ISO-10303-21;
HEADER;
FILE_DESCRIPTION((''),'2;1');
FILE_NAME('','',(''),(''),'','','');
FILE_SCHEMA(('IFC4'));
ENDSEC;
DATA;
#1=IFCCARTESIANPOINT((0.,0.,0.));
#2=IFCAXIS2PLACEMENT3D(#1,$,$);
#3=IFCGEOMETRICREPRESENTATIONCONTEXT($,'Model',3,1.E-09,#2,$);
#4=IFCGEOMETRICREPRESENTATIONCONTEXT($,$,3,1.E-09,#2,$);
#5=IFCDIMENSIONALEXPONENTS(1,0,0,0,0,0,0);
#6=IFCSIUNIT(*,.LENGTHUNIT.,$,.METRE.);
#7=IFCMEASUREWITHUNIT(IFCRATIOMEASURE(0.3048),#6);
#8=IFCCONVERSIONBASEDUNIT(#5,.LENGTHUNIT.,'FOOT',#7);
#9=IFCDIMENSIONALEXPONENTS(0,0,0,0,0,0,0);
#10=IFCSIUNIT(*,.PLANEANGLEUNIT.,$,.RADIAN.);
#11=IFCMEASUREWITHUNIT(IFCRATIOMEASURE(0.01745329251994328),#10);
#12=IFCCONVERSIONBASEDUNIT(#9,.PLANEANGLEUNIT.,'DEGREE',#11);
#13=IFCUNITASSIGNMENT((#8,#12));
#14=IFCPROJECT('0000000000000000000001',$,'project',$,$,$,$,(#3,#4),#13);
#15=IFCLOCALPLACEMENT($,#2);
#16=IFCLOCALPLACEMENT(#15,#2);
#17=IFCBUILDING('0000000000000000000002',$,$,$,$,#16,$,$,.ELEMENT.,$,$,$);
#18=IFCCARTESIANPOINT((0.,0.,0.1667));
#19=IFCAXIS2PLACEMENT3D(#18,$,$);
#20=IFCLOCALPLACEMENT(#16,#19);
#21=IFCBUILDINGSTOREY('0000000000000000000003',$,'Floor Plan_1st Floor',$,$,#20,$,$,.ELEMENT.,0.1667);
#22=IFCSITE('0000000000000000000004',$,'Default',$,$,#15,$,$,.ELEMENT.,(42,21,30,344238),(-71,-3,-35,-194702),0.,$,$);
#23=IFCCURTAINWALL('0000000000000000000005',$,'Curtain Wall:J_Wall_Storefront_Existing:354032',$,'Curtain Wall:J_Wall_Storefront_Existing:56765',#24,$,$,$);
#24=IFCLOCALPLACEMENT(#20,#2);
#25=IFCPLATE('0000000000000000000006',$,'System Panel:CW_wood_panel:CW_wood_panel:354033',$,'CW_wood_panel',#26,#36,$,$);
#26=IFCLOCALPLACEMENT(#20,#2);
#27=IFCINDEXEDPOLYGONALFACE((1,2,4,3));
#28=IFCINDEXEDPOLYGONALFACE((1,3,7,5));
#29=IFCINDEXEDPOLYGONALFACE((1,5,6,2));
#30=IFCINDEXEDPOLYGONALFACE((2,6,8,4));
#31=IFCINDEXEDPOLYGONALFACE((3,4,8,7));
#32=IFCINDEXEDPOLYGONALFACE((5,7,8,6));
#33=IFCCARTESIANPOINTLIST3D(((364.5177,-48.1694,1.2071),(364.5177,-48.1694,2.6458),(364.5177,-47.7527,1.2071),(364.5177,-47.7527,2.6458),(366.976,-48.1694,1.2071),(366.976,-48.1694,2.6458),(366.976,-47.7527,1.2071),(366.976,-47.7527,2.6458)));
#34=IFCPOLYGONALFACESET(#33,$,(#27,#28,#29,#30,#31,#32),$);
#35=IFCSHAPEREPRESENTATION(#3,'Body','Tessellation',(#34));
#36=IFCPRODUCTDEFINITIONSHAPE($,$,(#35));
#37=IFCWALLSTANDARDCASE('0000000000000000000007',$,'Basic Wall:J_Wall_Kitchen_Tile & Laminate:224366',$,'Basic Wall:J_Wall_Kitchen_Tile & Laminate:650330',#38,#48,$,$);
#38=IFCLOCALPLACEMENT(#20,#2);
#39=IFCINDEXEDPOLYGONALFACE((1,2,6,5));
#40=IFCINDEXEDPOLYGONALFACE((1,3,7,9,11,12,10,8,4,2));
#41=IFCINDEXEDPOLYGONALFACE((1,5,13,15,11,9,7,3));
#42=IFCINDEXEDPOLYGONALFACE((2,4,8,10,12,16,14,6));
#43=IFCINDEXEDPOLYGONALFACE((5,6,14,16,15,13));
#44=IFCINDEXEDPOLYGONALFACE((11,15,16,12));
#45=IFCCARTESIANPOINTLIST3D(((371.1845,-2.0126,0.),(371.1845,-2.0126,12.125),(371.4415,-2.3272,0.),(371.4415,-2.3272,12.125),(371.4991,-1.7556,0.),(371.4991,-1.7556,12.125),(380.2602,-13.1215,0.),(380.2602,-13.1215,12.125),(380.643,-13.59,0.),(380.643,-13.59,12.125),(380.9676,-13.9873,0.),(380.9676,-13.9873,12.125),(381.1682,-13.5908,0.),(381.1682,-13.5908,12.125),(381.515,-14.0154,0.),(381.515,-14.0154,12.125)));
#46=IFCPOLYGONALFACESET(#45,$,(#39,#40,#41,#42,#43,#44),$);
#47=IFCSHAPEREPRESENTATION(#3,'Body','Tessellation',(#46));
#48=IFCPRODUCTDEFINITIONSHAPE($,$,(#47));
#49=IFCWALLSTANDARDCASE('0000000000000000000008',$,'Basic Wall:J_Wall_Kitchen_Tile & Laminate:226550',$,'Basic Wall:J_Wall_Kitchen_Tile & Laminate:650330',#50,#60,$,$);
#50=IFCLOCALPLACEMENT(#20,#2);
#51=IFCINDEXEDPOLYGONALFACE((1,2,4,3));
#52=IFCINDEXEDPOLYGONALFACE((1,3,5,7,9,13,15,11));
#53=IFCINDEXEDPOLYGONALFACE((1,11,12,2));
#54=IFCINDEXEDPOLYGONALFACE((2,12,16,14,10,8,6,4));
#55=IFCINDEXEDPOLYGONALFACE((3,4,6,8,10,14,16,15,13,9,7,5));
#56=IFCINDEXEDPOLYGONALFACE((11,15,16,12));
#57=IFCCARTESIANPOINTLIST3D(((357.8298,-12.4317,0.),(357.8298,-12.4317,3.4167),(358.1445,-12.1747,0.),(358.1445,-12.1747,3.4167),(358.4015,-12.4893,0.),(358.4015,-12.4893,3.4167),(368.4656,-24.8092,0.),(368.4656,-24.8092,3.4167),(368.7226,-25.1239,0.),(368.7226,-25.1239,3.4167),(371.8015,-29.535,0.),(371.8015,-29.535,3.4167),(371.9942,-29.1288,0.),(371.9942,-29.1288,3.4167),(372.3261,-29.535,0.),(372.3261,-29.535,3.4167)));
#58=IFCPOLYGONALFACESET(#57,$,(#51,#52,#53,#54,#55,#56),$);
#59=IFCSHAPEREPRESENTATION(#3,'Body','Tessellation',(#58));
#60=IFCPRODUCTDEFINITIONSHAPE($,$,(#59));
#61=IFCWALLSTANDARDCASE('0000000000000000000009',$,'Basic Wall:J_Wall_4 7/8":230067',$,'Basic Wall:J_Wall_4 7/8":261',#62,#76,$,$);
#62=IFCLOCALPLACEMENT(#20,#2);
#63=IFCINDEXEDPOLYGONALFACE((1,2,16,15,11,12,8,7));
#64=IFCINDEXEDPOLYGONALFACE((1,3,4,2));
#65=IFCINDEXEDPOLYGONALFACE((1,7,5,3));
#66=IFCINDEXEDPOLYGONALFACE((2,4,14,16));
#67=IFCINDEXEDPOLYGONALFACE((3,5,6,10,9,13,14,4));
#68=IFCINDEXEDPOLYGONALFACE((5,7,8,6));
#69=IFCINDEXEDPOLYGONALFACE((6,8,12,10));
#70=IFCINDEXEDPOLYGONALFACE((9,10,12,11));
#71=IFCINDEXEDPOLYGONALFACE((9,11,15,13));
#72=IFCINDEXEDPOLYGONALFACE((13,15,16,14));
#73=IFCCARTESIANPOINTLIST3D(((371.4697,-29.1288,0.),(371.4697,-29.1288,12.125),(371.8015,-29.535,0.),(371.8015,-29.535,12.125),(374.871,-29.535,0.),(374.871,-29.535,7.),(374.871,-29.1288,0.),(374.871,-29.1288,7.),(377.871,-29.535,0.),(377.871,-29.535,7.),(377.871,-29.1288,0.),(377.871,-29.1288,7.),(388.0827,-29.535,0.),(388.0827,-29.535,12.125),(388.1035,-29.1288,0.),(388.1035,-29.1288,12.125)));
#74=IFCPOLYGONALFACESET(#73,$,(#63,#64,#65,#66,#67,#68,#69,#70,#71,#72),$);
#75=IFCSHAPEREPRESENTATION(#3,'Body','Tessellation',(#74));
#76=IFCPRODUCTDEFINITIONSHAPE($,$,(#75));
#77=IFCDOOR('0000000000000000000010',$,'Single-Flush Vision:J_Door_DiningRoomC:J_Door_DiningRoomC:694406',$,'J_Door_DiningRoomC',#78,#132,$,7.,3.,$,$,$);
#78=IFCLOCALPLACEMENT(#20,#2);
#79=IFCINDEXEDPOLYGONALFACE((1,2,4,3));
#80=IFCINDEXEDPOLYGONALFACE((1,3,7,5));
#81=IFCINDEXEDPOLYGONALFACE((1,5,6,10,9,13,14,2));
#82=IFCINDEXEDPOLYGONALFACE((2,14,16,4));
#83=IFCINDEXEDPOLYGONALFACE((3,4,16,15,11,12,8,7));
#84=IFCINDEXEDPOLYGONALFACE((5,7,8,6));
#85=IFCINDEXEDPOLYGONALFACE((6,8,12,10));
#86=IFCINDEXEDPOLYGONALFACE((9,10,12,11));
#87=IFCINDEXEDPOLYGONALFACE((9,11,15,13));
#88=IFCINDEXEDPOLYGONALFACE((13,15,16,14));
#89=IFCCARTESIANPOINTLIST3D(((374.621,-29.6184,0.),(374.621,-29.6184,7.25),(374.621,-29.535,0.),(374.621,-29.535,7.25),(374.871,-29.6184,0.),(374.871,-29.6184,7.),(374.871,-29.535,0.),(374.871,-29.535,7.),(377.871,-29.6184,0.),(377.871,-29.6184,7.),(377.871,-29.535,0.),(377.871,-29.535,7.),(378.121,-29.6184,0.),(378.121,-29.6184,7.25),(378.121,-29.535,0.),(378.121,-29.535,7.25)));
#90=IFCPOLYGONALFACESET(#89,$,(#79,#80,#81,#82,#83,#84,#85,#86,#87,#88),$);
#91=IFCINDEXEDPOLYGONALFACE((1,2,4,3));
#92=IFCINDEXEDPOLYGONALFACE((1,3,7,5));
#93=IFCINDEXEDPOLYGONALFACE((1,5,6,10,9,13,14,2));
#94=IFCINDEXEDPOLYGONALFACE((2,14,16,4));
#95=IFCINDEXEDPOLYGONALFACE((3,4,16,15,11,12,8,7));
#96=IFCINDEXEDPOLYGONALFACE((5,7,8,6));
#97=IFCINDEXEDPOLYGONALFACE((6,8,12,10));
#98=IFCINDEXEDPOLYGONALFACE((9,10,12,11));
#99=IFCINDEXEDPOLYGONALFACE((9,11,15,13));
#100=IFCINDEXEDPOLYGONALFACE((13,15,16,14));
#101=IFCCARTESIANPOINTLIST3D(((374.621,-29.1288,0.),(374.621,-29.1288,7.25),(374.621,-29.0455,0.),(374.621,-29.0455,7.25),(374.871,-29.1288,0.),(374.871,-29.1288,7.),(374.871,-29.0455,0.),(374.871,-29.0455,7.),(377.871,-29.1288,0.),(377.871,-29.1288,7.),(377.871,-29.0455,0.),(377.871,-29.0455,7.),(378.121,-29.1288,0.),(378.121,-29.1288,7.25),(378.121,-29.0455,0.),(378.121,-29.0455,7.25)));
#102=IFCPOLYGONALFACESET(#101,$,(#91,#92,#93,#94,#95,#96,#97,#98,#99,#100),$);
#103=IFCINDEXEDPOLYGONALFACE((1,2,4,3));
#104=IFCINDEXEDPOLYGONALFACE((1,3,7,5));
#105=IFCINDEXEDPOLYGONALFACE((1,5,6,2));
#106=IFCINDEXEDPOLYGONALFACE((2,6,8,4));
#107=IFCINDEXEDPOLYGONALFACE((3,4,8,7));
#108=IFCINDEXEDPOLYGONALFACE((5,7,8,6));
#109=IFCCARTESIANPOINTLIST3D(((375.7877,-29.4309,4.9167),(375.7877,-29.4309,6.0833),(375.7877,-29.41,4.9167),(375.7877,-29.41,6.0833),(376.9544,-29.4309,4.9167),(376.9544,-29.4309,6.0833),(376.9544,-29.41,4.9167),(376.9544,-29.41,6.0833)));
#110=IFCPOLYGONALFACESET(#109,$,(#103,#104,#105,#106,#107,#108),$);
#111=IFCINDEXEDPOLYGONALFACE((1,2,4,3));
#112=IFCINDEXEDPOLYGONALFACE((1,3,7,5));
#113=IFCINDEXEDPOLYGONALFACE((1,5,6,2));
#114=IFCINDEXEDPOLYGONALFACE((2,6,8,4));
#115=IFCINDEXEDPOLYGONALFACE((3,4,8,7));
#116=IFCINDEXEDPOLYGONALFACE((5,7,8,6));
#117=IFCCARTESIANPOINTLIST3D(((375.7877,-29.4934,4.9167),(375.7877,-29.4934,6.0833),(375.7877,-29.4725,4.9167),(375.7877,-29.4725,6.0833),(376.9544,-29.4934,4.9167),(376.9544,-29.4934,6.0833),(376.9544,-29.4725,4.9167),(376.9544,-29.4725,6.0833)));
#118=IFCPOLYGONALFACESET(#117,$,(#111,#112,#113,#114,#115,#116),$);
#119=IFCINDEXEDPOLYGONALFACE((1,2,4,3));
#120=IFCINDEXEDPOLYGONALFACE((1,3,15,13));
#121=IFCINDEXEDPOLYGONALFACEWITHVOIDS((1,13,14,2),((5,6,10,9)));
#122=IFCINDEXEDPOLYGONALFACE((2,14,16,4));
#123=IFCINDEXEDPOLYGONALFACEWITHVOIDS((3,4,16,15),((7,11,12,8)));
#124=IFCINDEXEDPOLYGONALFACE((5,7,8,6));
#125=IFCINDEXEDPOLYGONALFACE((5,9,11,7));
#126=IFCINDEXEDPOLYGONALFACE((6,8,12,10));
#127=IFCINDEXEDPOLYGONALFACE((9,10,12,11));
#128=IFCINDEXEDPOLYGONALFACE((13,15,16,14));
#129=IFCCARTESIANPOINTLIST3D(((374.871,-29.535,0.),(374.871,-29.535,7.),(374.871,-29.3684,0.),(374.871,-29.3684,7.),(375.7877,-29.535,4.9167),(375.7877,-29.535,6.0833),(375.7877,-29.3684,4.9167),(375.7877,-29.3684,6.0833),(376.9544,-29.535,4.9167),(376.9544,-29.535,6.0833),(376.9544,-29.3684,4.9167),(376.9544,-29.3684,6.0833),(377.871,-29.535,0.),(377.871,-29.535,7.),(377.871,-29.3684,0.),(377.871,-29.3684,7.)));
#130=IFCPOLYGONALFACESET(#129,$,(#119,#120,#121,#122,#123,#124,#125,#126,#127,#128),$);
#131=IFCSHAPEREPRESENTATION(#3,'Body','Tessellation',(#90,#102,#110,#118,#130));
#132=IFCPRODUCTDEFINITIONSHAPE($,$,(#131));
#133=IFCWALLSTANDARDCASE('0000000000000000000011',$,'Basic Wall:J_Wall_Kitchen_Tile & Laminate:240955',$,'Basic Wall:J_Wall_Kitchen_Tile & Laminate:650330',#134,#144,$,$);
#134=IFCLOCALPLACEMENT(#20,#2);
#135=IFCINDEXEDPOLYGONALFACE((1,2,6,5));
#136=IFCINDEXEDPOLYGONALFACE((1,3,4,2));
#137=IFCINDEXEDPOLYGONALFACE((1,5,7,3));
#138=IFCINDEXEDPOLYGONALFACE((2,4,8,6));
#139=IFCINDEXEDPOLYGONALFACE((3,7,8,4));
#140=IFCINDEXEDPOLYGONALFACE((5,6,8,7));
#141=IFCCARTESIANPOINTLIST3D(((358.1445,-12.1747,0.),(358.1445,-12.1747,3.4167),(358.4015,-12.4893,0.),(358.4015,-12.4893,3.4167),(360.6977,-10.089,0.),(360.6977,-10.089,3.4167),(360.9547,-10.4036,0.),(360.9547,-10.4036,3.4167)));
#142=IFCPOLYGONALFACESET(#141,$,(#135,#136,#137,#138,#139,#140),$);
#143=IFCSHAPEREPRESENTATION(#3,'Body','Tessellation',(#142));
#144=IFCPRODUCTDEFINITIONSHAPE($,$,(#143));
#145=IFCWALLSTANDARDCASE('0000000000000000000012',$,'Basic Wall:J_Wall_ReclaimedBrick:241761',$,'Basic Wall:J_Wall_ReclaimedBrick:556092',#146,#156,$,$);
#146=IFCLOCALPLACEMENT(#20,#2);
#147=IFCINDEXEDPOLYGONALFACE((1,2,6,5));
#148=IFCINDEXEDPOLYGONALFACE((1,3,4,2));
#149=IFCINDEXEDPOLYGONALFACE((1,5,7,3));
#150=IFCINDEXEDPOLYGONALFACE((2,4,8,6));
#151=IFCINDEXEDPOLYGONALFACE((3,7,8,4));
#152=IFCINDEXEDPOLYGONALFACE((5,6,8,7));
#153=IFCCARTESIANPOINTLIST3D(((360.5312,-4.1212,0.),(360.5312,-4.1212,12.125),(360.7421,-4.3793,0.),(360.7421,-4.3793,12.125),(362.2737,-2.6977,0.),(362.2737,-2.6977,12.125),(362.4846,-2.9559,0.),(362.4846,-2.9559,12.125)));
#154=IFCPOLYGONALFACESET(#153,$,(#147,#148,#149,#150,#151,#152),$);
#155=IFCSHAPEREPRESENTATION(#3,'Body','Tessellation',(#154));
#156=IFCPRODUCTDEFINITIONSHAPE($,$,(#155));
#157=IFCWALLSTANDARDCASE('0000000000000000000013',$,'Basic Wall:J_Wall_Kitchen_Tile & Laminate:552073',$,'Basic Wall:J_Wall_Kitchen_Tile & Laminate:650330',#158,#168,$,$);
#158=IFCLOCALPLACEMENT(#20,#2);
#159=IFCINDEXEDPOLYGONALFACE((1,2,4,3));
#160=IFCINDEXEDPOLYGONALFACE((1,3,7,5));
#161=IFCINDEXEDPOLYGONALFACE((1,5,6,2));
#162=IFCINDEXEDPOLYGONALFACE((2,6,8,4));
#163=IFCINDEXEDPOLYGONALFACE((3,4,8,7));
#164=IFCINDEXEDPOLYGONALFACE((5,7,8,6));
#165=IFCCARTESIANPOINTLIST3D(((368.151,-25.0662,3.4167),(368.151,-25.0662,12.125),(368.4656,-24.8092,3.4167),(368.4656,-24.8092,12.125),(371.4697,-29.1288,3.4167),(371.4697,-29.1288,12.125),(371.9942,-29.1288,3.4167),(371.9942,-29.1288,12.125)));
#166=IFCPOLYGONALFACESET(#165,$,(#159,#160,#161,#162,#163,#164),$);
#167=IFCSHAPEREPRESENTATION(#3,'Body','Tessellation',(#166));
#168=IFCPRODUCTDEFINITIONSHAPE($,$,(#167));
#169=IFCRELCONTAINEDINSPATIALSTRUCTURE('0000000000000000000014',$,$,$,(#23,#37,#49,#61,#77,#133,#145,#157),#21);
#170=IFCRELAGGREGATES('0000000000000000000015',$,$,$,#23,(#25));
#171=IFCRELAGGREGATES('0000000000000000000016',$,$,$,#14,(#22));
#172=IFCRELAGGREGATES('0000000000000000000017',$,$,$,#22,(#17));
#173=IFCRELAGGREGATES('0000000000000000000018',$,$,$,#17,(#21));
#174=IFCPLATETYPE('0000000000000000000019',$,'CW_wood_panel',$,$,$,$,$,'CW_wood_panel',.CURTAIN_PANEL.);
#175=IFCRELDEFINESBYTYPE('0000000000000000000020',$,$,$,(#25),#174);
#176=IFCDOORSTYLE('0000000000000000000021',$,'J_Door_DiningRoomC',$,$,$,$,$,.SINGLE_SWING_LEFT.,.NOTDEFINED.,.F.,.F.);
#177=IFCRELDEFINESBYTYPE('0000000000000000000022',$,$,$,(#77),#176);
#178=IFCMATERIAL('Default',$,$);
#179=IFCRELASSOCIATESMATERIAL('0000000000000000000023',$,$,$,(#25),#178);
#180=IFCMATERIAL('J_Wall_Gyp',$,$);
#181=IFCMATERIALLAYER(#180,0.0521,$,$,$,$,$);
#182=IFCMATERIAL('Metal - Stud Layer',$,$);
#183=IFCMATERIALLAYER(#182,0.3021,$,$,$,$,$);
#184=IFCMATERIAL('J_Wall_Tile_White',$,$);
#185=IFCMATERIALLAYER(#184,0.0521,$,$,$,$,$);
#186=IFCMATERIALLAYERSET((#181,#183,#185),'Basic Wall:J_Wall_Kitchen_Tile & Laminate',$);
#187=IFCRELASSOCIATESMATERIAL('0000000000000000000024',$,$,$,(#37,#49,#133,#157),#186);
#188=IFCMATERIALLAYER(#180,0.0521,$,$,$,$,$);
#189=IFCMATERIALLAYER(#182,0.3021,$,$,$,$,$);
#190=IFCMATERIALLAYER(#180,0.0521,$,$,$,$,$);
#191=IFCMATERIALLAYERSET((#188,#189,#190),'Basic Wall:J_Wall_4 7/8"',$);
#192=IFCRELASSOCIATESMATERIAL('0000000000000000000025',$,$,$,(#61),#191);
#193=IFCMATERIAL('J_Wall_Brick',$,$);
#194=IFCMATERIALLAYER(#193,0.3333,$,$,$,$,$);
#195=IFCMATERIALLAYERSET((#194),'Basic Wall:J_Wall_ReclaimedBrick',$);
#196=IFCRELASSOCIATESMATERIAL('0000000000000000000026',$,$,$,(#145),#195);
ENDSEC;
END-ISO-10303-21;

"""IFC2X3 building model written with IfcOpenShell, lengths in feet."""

from ifc_helpers import new_model, entity, si_unit, converted_unit, frame, frame_2d, origin, origin_2d_with_axis, place, context, project, spatial, polyline, rectangle, outline, extrude, source, transform, mapped, material, layer, layer_set, layer_usage, type_object, type_shapes, element, fill, aggregate, save


model = new_model("IFC2X3")

# Units and contexts
model_context = context("Model", 3, precision=1e-09, world=origin())
context_of_model = context(None, 3, precision=1e-09, world=origin())
ifc_project = project(units=[converted_unit("LENGTHUNIT", "FOOT", entity("IfcRatioMeasure", 0.3048), si_unit("LENGTHUNIT", "METRE"), dimensions=[1, 0, 0, 0, 0, 0, 0]), converted_unit("PLANEANGLEUNIT", "DEGREE", entity("IfcRatioMeasure", 0.01745329251994328), si_unit("PLANEANGLEUNIT", "RADIAN"), dimensions=[0, 0, 0, 0, 0, 0, 0])], contexts=[model_context, context_of_model])

# Site, building, storey
site_placement = place(None, origin())
site = spatial("IfcSite", under=ifc_project, at=site_placement, Name="Default", CompositionType="ELEMENT", RefLatitude=(42, 21, 30, 344238), RefLongitude=(-71, -3, -35, -194702), RefElevation=0.0)
building_placement = place(site_placement, origin())
building = spatial("IfcBuilding", under=site, at=building_placement, CompositionType="ELEMENT")
storey_placement = place(building_placement, frame((0.0, 0.0, 0.1667)))
storey = spatial("IfcBuildingStorey", under=building, at=storey_placement, Name="Floor Plan_1st Floor", CompositionType="ELEMENT", Elevation=0.1667)

# Curtain wall
curtain_wall_1_placement = place(storey_placement, origin())
curtain_wall_1 = element("IfcCurtainWall", 1, at=curtain_wall_1_placement, inside=storey, Name="Curtain Wall:J_Wall_Storefront_Existing:354032", ObjectType="Curtain Wall:J_Wall_Storefront_Existing:56765")

# Plate
ifc_material_1 = material(Name="Default")
plate_type_1 = type_object("IfcPlateType", Name="CW_wood_panel", ElementType="CW_wood_panel", PredefinedType="CURTAIN_PANEL")
shared_shape_1 = source(origin(), model_context, "Body", "SweptSolid", [
    extrude(rectangle(XDim=0.4167, YDim=2.4583, at=origin_2d_with_axis()), frame((0.0, 0.0, 0.0), z_axis=(0.0, 0.0, 1.0), x_axis=(0.0, 1.0, 0.0)), (0.0, 0.0, 1.0), 1.4388),
])
type_shapes(plate_type_1, [shared_shape_1])
plate_1_placement = place(storey_placement, frame((365.7469, -47.9611, 1.2071)))
plate_1 = element("IfcPlate", 2, at=plate_1_placement, type_object=plate_type_1, material=ifc_material_1, Name="System Panel:CW_wood_panel:CW_wood_panel:354033", ObjectType="CW_wood_panel", context=model_context, shape_type="MappedRepresentation", body=[
    mapped(shared_shape_1, transform((0.0, 0.0, 0.0), scale=1.0)),
])
aggregate(curtain_wall_1, [plate_1])

# Walls
ifc_material_2 = material(Name="J_Wall_Gyp")
ifc_layer_1 = layer(ifc_material_2, 0.0521)
ifc_material_3 = material(Name="Metal - Stud Layer")
ifc_layer_2 = layer(ifc_material_3, 0.3021)
ifc_material_4 = material(Name="J_Wall_Tile_White")
ifc_layer_3 = layer(ifc_material_4, 0.0521)
ifc_layer_set_1 = layer_set([ifc_layer_1, ifc_layer_2, ifc_layer_3], Name="Basic Wall:J_Wall_Kitchen_Tile & Laminate")
ifc_layer_usage_1 = layer_usage(ifc_layer_set_1, "AXIS2", "NEGATIVE", 0.2031)
wall_1_placement = place(storey_placement, frame((371.3418, -1.8841, 0.0), z_axis=(0.0, 0.0, 1.0), x_axis=(0.63268, -0.774414, 0.0)))
element("IfcWallStandardCase", 3, at=wall_1_placement, inside=storey, material=ifc_layer_usage_1, Name="Basic Wall:J_Wall_Kitchen_Tile & Laminate:224366", ObjectType="Basic Wall:J_Wall_Kitchen_Tile & Laminate:650330", context=model_context, shape_type="SweptSolid", body=[
    extrude(outline(polyline([(15.4629, -0.2031), (15.831, 0.2031), (15.2828, 0.2031), (0.0, 0.2031), (0.0, -0.2031), (0.4063, -0.2031), (14.3448, -0.2031), (14.9498, -0.2031), (15.4629, -0.2031)])), origin(), (0.0, 0.0, 1.0), 12.125),
])
ifc_layer_usage_2 = layer_usage(ifc_layer_set_1, "AXIS2", "NEGATIVE", 0.2031)
wall_2_placement = place(storey_placement, frame((372.1688, -29.6636, 0.0), z_axis=(0.0, 0.0, 1.0), x_axis=(-0.632643, 0.774444, 0.0)))
element("IfcWallStandardCase", 4, at=wall_2_placement, inside=storey, material=ifc_layer_usage_2, Name="Basic Wall:J_Wall_Kitchen_Tile & Laminate:226550", ObjectType="Basic Wall:J_Wall_Kitchen_Tile & Laminate:650330", context=model_context, shape_type="SweptSolid", body=[
    extrude(outline(polyline([(22.4165, -0.2031), (22.4165, 0.2031), (0.3319, 0.2031), (0.0, -0.2031), (0.5246, -0.2031), (5.6959, -0.2031), (6.1022, -0.2031), (22.0103, -0.2031), (22.4165, -0.2031)])), origin(), (0.0, 0.0, 1.0), 3.4167),
])

# Wall, opening, door
ifc_layer_4 = layer(ifc_material_2, 0.0521)
ifc_layer_5 = layer(ifc_material_3, 0.3021)
ifc_layer_6 = layer(ifc_material_2, 0.0521)
ifc_layer_set_2 = layer_set([ifc_layer_4, ifc_layer_5, ifc_layer_6], Name="Basic Wall:J_Wall_4 7/8\"")
ifc_layer_usage_3 = layer_usage(ifc_layer_set_2, "AXIS2", "NEGATIVE", 0.2031)
wall_3_placement = place(storey_placement, frame((371.4697, -29.3319, 0.0)))
wall_3 = element("IfcWallStandardCase", 5, at=wall_3_placement, inside=storey, material=ifc_layer_usage_3, Name="Basic Wall:J_Wall_4 7/8\":230067", ObjectType="Basic Wall:J_Wall_4 7/8\":261", context=model_context, shape_type="SweptSolid", body=[
    extrude(outline(polyline([(0.3319, -0.2031), (16.6131, -0.2031), (16.6339, 0.2031), (8.3777, 0.2031), (7.9709, 0.2031), (0.5246, 0.2031), (0.0, 0.2031), (0.3319, -0.2031)])), origin(), (0.0, 0.0, 1.0), 12.125),
])
opening_1_placement = place(wall_3_placement, frame((6.4014, 0.2031, 0.0)))
opening_1 = element("IfcOpeningElement", 6, at=opening_1_placement, cuts=wall_3, ObjectType="Opening", context=model_context, shape_type="SweptSolid", body=[
    extrude(rectangle(XDim=3.0, YDim=7.0, at=frame_2d((3.5, 1.5), x_axis=(0.0, -1.0))), frame((0.0, 0.0, 0.0), z_axis=(0.0, -1.0, 0.0), x_axis=(0.0, 0.0, 1.0)), (0.0, 0.0, 1.0), 0.4062),
])
door_style = type_object("IfcDoorStyle", Name="J_Door_DiningRoomC", ConstructionType="NOTDEFINED", OperationType="SINGLE_SWING_LEFT", ParameterTakesPrecedence=False, Sizeable=False)
shared_shape_2 = source(origin(), model_context, "Body", "SweptSolid", [
    extrude(outline(polyline([(-1.75, -3.6875), (1.75, -3.6875), (1.75, 3.5625), (1.5, 3.5625), (1.5, -3.4375), (-1.5, -3.4375), (-1.5, 3.5625), (-1.75, 3.5625), (-1.75, -3.6875)])), frame((1.5, 0.4896, 3.5625), z_axis=(0.0, -1.0, 0.0), x_axis=(-1.0, 0.0, 0.0)), (0.0, 0.0, 1.0), 0.0833),
    extrude(outline(polyline([(-1.5, -3.4375), (-1.5, 3.5625), (-1.75, 3.5625), (-1.75, -3.6875), (1.75, -3.6875), (1.75, 3.5625), (1.5, 3.5625), (1.5, -3.4375), (-1.5, -3.4375)])), frame((1.5, 0.0, 3.5625), z_axis=(0.0, 1.0, 0.0), x_axis=(1.0, 0.0, 0.0)), (0.0, 0.0, -1.0), 0.0833),
    extrude(rectangle(XDim=1.1667, YDim=0.0208, at=origin_2d_with_axis()), frame((1.5, 0.2917, 4.9167)), (0.0, 0.0, 1.0), 1.1667),
    extrude(rectangle(XDim=1.1667, YDim=0.0208, at=origin_2d_with_axis()), frame((1.5, 0.3542, 4.9167)), (0.0, 0.0, 1.0), 1.1667),
    extrude(outline(polyline([(-1.5, -3.5), (1.5, -3.5), (1.5, 3.5), (-1.5, 3.5), (-1.5, -3.5)]), holes=[polyline([(-0.5833, -2.5833), (-0.5833, -1.4167), (0.5833, -1.4167), (0.5833, -2.5833), (-0.5833, -2.5833)])]), frame((1.5, 0.4063, 3.5), z_axis=(0.0, -1.0, 0.0), x_axis=(-1.0, 0.0, 0.0)), (0.0, 0.0, 1.0), 0.1667),
])
type_shapes(door_style, [shared_shape_2])
door_placement = place(opening_1_placement, frame((0.0, 0.0, 0.0), z_axis=(0.0, 0.0, 1.0), x_axis=(-1.0, 0.0, 0.0)))
door = element("IfcDoor", 7, at=door_placement, inside=storey, type_object=door_style, Name="Single-Flush Vision:J_Door_DiningRoomC:J_Door_DiningRoomC:694406", ObjectType="J_Door_DiningRoomC", OverallHeight=7.0, OverallWidth=3.0, context=model_context, shape_type="MappedRepresentation", body=[
    mapped(shared_shape_2, transform((0.0, 0.0, 0.0), scale=1.0)),
])
fill(opening_1, door)

# Walls
ifc_layer_usage_4 = layer_usage(ifc_layer_set_1, "AXIS2", "POSITIVE", -0.2031)
wall_4_placement = place(storey_placement, frame((360.8262, -10.2463, 0.0), z_axis=(0.0, 0.0, 1.0), x_axis=(-0.774444, -0.632643, 0.0)))
element("IfcWallStandardCase", 8, at=wall_4_placement, inside=storey, material=ifc_layer_usage_4, Name="Basic Wall:J_Wall_Kitchen_Tile & Laminate:240955", ObjectType="Basic Wall:J_Wall_Kitchen_Tile & Laminate:650330", context=model_context, shape_type="SweptSolid", body=[
    extrude(rectangle(XDim=3.2969, YDim=0.4063, at=frame_2d((1.6484, 0.0), x_axis=(-1.0, 0.0))), origin(), (0.0, 0.0, 1.0), 3.4167),
])
ifc_material_5 = material(Name="J_Wall_Brick")
ifc_layer_7 = layer(ifc_material_5, 0.3333)
ifc_layer_set_3 = layer_set([ifc_layer_7], Name="Basic Wall:J_Wall_ReclaimedBrick")
ifc_layer_usage_5 = layer_usage(ifc_layer_set_3, "AXIS2", "POSITIVE", -0.1667)
wall_5_placement = place(storey_placement, frame((360.6367, -4.2503, 0.0), z_axis=(0.0, 0.0, 1.0), x_axis=(0.774444, 0.632643, 0.0)))
element("IfcWallStandardCase", 9, at=wall_5_placement, inside=storey, material=ifc_layer_usage_5, Name="Basic Wall:J_Wall_ReclaimedBrick:241761", ObjectType="Basic Wall:J_Wall_ReclaimedBrick:556092", context=model_context, shape_type="SweptSolid", body=[
    extrude(rectangle(XDim=2.25, YDim=0.3333, at=frame_2d((1.125, 0.0), x_axis=(-1.0, 0.0))), origin(), (0.0, 0.0, 1.0), 12.125),
])

# Wall
ifc_layer_usage_6 = layer_usage(ifc_layer_set_1, "AXIS2", "POSITIVE", -0.2031)
wall_6_placement = place(storey_placement, frame((368.3083, -24.9377, 3.4167), z_axis=(0.0, 0.0, 1.0), x_axis=(0.632643, -0.774444, 0.0)))
element("IfcWallStandardCase", 10, at=wall_6_placement, inside=storey, material=ifc_layer_usage_6, Name="Basic Wall:J_Wall_Kitchen_Tile & Laminate:552073", ObjectType="Basic Wall:J_Wall_Kitchen_Tile & Laminate:650330", context=model_context, shape_type="SweptSolid", body=[
    extrude(outline(polyline([(5.2458, -0.2031), (5.5776, 0.2031), (0.0, 0.2031), (0.0, -0.2031), (5.2458, -0.2031)])), origin(), (0.0, 0.0, 1.0), 8.7083),
])

save(model, "model.ifc")
